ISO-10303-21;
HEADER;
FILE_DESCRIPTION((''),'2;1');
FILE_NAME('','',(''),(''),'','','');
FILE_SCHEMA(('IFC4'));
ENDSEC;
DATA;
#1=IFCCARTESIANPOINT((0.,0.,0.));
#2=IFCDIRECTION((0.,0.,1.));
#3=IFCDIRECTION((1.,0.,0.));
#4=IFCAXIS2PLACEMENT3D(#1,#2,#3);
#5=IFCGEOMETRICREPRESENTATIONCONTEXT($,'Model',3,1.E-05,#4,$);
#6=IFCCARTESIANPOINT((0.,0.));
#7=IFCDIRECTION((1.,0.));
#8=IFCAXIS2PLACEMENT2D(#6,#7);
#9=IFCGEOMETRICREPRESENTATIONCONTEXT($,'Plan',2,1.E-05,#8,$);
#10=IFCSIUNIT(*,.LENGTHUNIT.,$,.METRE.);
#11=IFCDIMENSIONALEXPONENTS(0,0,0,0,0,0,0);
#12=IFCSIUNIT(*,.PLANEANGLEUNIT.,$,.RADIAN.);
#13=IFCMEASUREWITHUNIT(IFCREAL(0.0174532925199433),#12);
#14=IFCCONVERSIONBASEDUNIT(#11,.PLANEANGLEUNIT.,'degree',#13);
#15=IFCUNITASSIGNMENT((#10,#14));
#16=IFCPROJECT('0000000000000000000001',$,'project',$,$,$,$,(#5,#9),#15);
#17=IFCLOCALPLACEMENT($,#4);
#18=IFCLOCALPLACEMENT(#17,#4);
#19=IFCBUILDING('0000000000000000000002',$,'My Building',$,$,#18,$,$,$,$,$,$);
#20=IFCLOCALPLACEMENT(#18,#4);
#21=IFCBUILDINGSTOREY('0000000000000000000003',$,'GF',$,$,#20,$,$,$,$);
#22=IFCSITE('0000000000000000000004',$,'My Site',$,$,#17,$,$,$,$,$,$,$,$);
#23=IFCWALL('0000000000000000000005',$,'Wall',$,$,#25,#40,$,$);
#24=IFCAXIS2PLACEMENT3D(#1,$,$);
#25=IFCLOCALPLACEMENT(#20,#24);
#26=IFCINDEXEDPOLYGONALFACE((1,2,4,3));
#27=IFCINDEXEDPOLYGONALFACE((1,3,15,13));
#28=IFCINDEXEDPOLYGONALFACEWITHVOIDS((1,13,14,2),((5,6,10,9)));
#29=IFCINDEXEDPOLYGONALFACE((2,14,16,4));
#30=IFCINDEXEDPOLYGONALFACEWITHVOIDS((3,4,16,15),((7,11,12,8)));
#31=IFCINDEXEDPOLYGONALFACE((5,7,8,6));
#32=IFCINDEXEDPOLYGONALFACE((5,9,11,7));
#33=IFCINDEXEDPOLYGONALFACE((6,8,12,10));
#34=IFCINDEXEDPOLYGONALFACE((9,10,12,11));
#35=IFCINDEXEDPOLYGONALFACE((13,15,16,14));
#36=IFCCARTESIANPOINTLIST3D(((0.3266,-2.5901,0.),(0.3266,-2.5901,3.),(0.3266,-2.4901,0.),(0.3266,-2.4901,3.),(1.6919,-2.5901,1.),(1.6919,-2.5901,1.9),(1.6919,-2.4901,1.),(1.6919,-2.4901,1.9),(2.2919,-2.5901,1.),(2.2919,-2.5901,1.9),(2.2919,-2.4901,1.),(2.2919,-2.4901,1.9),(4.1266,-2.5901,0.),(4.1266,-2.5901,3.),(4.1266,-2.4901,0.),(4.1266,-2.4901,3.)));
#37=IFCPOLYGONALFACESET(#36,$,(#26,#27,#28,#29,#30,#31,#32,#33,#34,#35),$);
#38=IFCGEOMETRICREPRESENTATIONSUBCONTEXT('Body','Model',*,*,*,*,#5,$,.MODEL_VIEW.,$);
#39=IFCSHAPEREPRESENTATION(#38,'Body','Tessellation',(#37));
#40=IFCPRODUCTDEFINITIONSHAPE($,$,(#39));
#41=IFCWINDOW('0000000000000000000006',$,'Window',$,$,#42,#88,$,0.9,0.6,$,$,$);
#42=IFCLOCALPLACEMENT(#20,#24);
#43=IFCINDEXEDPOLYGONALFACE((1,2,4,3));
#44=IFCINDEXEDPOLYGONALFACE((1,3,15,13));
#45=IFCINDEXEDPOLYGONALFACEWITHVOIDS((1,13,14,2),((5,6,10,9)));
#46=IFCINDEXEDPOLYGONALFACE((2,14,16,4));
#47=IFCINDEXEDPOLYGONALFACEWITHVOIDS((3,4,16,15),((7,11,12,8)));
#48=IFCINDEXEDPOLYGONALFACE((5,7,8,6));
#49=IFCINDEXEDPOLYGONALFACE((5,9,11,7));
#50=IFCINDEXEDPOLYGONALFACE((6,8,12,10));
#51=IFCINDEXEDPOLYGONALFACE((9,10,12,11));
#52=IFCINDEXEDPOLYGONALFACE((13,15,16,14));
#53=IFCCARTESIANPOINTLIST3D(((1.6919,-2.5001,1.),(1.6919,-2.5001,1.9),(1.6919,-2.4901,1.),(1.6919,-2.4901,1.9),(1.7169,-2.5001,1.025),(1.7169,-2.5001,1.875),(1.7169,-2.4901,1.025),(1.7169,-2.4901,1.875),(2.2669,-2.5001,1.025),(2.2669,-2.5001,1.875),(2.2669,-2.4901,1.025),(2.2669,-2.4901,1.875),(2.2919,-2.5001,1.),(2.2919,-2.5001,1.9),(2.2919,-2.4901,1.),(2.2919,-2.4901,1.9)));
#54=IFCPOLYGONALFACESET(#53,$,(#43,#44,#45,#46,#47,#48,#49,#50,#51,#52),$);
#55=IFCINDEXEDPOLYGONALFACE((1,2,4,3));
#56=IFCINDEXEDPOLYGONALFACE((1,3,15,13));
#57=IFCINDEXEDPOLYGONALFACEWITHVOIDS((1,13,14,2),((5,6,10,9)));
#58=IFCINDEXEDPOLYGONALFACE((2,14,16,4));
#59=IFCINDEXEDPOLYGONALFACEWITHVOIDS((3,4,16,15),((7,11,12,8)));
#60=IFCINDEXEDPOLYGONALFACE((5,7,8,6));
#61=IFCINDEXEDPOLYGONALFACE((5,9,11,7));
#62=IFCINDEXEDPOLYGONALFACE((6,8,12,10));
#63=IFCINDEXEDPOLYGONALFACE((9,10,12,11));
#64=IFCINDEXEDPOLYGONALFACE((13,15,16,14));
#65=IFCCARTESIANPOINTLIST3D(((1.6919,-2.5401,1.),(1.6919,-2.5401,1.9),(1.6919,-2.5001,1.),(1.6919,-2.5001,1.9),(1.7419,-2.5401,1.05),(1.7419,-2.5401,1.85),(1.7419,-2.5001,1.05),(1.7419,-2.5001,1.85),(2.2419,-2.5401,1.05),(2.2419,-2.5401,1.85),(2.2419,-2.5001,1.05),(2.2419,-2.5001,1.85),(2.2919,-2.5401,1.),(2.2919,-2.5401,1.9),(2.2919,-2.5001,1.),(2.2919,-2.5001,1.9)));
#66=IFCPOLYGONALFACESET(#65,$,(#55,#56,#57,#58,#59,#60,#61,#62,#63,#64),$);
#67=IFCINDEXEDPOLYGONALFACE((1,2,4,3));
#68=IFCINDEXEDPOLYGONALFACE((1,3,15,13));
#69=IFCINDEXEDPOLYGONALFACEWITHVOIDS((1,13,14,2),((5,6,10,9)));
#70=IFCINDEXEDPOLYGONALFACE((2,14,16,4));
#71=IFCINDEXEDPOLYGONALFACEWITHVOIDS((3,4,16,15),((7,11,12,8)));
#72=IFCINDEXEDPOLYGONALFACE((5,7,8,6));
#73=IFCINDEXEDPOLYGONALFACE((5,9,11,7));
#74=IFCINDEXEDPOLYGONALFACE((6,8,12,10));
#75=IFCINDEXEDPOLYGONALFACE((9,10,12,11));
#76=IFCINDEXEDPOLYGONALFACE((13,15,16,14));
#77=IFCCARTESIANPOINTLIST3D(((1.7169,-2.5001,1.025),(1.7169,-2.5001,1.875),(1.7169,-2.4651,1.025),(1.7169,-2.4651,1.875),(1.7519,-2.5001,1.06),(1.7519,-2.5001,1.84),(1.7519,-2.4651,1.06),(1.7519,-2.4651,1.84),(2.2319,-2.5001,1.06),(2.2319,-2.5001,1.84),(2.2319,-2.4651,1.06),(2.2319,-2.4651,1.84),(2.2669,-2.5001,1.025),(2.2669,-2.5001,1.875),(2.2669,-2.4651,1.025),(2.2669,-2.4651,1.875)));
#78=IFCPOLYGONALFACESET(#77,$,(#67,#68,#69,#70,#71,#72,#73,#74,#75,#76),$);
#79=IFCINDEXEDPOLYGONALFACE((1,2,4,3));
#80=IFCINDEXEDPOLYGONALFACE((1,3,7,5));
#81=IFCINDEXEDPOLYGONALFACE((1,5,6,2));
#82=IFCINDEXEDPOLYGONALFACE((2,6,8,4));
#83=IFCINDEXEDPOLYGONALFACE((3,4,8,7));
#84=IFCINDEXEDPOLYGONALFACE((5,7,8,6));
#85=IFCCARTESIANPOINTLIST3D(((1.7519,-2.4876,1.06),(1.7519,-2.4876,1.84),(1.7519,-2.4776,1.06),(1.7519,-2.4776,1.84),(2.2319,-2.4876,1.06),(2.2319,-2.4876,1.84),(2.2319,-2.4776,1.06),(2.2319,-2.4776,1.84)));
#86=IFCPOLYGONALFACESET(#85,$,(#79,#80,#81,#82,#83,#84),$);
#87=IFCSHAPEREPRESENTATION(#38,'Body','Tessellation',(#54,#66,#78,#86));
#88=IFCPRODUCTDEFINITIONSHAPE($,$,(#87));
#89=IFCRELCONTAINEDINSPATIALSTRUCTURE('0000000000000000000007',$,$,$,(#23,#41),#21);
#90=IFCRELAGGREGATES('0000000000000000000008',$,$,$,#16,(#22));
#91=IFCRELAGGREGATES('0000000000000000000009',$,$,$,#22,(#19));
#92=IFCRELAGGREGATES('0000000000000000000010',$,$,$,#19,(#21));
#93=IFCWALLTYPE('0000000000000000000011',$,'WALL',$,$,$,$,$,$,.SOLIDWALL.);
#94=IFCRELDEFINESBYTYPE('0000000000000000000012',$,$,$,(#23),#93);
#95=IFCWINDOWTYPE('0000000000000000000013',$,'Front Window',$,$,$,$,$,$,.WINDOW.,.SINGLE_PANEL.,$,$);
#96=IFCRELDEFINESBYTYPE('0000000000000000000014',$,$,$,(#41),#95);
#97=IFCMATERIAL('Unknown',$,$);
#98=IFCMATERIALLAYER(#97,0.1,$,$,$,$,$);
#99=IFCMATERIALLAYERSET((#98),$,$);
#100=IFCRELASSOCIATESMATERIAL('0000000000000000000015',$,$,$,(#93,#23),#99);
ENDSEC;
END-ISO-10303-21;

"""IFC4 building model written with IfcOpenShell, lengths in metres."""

from ifc_helpers import new_model, entity, si_unit, converted_unit, frame, origin_with_axes, origin_2d_with_axis, place, context, subcontext, project, spatial, line, indexed_curve, outline, extrude, shape, source, transform, mapped, material, layer, layer_set, layer_usage, type_object, type_shapes, element, fill, save


model = new_model("IFC4")

# Units and contexts
model_context = context("Model", 3, precision=1e-05, world=origin_with_axes())
plan_context = context("Plan", 2, precision=1e-05, world=origin_2d_with_axis())
body_context_1 = subcontext(model_context, "Body", "Model", "MODEL_VIEW")
body_context_2 = subcontext(plan_context, "Body", "Plan", "PLAN_VIEW")
ifc_project = project(units=[si_unit("LENGTHUNIT", "METRE"), converted_unit("PLANEANGLEUNIT", "degree", entity("IfcReal", 0.0174532925199433), si_unit("PLANEANGLEUNIT", "RADIAN"), dimensions=[0, 0, 0, 0, 0, 0, 0])], contexts=[model_context, plan_context])

# Site, building, storey
site_placement = place(None, origin_with_axes())
site = spatial("IfcSite", under=ifc_project, at=site_placement, Name="My Site")
building_placement = place(site_placement, origin_with_axes())
building = spatial("IfcBuilding", under=site, at=building_placement, Name="My Building")
storey_placement = place(building_placement, origin_with_axes())
storey = spatial("IfcBuildingStorey", under=building, at=storey_placement, Name="GF")

# Shared definitions
ifc_material_1 = material(Name="Unknown")

# Shared definitions
ifc_layer_1 = layer(ifc_material_1, 0.1)
ifc_layer_set_1 = layer_set([ifc_layer_1])
wall_type = type_object("IfcWallType", Name="WALL", PredefinedType="SOLIDWALL", material=ifc_layer_set_1)

# Wall, opening, window
ifc_layer_usage_1 = layer_usage(ifc_layer_set_1, "AXIS2", "POSITIVE", 0.0)
wall_1_placement = place(storey_placement, frame((0.3266, -2.5901, 0.0), z_axis=(0.0, 0.0, 1.0), x_axis=(1.0, 0.0, 0.0)))
wall_1 = element("IfcWall", 1, at=wall_1_placement, inside=storey, type_object=wall_type, material=ifc_layer_usage_1, Name="Wall", context=body_context_1, shape_type="SweptSolid", body=[
    extrude(outline(indexed_curve([(0.0, 0.0), (0.0, 0.1), (3.8, 0.1), (3.8, 0.0)], segments=[line(1, 2, 3, 4, 1)])), origin_with_axes(), (0.0, 0.0, 1.0), 3.0),
])
shared_shape_1 = source(origin_with_axes(), body_context_1, "Body", "SweptSolid", [
    extrude(outline(indexed_curve([(0.0, 0.0), (0.6, 0.0), (0.6, 0.9), (0.0, 0.9)], segments=[line(1, 2, 3, 4, 1)])), frame((0.0, -0.6, 0.0), z_axis=(0.0, -1.0, 0.0), x_axis=(1.0, 0.0, 0.0)), (0.0, 0.0, -1.0), 1.2),
])
opening_1_placement = place(wall_1_placement, frame((1.3653, 0.0, 1.0), z_axis=(0.0, 0.0, 1.0), x_axis=(1.0, 0.0, 0.0)))
opening_1 = element("IfcOpeningElement", 2, at=opening_1_placement, cuts=wall_1, PredefinedType="OPENING", context=body_context_1, shape_type="MappedRepresentation", body=[
    mapped(shared_shape_1, transform((0.0, 0.0, 0.0), x_axis=(1.0, 0.0, 0.0), y_axis=(0.0, 1.0, 0.0), z_axis=(0.0, 0.0, 1.0), scale=1.0)),
])
window_type_1 = type_object("IfcWindowType", Name="Front Window", PartitioningType="SINGLE_PANEL", PredefinedType="WINDOW")
shared_shape_2 = source(origin_with_axes(), body_context_1, "Body", "SweptSolid", [
    extrude(outline(indexed_curve([(0.0, 0.0), (0.6, 0.0), (0.6, 0.9), (0.0, 0.9)], segments=[line(1, 2, 3, 4, 1)]), holes=[indexed_curve([(0.025, 0.025), (0.575, 0.025), (0.575, 0.875), (0.025, 0.875)], segments=[line(1, 2, 3, 4, 1)])]), frame((0.0, 0.09, 0.0), z_axis=(0.0, -1.0, 0.0), x_axis=(1.0, 0.0, 0.0)), (0.0, 0.0, -1.0), 0.01),
    extrude(outline(indexed_curve([(0.0, 0.0), (0.6, 0.0), (0.6, 0.9), (0.0, 0.9)], segments=[line(1, 2, 3, 4, 1)]), holes=[indexed_curve([(0.05, 0.05), (0.55, 0.05), (0.55, 0.85), (0.05, 0.85)], segments=[line(1, 2, 3, 4, 1)])]), frame((0.0, 0.05, 0.0), z_axis=(0.0, -1.0, 0.0), x_axis=(1.0, 0.0, 0.0)), (0.0, 0.0, -1.0), 0.04),
    extrude(outline(indexed_curve([(0.0, 0.0), (0.55, 0.0), (0.55, 0.85), (0.0, 0.85)], segments=[line(1, 2, 3, 4, 1)]), holes=[indexed_curve([(0.035, 0.035), (0.515, 0.035), (0.515, 0.815), (0.035, 0.815)], segments=[line(1, 2, 3, 4, 1)])]), frame((0.025, 0.09, 0.025), z_axis=(0.0, -1.0, 0.0), x_axis=(1.0, 0.0, 0.0)), (0.0, 0.0, -1.0), 0.035),
    extrude(outline(indexed_curve([(0.035, 0.035), (0.515, 0.035), (0.515, 0.815), (0.035, 0.815)], segments=[line(1, 2, 3, 4, 1)])), frame((0.025, 0.1025, 0.025), z_axis=(0.0, -1.0, 0.0), x_axis=(1.0, 0.0, 0.0)), (0.0, 0.0, -1.0), 0.01),
])
shared_shape_3 = source(origin_with_axes(), body_context_2, "Body", "Curve2D", [
    entity("IfcIndexedPolyCurve", entity("IfcCartesianPointList2D", [[0.05, 0.05], [0.55, 0.05]])),
    entity("IfcIndexedPolyCurve", entity("IfcCartesianPointList2D", [[0.0, 0.1], [0.025, 0.1], [0.025, 0.09], [0.05, 0.09], [0.05, 0.05], [0.0, 0.05]]), [entity("IfcLineIndex", [1, 2, 3, 4, 5, 6, 1])]),
    entity("IfcIndexedPolyCurve", entity("IfcCartesianPointList2D", [[0.6, 0.1], [0.575, 0.1], [0.575, 0.09], [0.55, 0.09], [0.55, 0.05], [0.6, 0.05]]), [entity("IfcLineIndex", [1, 2, 3, 4, 5, 6, 1])]),
    entity("IfcIndexedPolyCurve", entity("IfcCartesianPointList2D", [[0.025, 0.09], [0.06, 0.09], [0.06, 0.125], [0.025, 0.125]]), [entity("IfcLineIndex", [1, 2, 3, 4, 1])]),
    entity("IfcIndexedPolyCurve", entity("IfcCartesianPointList2D", [[0.575, 0.09], [0.54, 0.09], [0.54, 0.125], [0.575, 0.125]]), [entity("IfcLineIndex", [1, 2, 3, 4, 1])]),
    entity("IfcIndexedPolyCurve", entity("IfcCartesianPointList2D", [[0.06, 0.09], [0.54, 0.09]])),
    entity("IfcIndexedPolyCurve", entity("IfcCartesianPointList2D", [[0.06, 0.125], [0.54, 0.125]])),
    entity("IfcIndexedPolyCurve", entity("IfcCartesianPointList2D", [[0.06, 0.1075], [0.54, 0.1075]])),
])
type_shapes(window_type_1, [shared_shape_2, shared_shape_3])
window_1_placement = place(opening_1_placement, origin_with_axes())
window_1 = element("IfcWindow", 3, at=window_1_placement, inside=storey, type_object=window_type_1, Name="Window", OverallHeight=0.9, OverallWidth=0.6, shapes=[
    shape(body_context_1, "Body", "MappedRepresentation", [mapped(shared_shape_2, transform((0.0, 0.0, 0.0), x_axis=(1.0, 0.0, 0.0), y_axis=(0.0, 1.0, 0.0), z_axis=(0.0, 0.0, 1.0), scale=1.0))]),
    shape(body_context_2, "Body", "MappedRepresentation", [mapped(shared_shape_3, transform((0.0, 0.0, 0.0), x_axis=(1.0, 0.0, 0.0), y_axis=(0.0, 1.0, 0.0), z_axis=(0.0, 0.0, 1.0), scale=1.0))]),
])
fill(opening_1, window_1)

save(model, "model.ifc")
